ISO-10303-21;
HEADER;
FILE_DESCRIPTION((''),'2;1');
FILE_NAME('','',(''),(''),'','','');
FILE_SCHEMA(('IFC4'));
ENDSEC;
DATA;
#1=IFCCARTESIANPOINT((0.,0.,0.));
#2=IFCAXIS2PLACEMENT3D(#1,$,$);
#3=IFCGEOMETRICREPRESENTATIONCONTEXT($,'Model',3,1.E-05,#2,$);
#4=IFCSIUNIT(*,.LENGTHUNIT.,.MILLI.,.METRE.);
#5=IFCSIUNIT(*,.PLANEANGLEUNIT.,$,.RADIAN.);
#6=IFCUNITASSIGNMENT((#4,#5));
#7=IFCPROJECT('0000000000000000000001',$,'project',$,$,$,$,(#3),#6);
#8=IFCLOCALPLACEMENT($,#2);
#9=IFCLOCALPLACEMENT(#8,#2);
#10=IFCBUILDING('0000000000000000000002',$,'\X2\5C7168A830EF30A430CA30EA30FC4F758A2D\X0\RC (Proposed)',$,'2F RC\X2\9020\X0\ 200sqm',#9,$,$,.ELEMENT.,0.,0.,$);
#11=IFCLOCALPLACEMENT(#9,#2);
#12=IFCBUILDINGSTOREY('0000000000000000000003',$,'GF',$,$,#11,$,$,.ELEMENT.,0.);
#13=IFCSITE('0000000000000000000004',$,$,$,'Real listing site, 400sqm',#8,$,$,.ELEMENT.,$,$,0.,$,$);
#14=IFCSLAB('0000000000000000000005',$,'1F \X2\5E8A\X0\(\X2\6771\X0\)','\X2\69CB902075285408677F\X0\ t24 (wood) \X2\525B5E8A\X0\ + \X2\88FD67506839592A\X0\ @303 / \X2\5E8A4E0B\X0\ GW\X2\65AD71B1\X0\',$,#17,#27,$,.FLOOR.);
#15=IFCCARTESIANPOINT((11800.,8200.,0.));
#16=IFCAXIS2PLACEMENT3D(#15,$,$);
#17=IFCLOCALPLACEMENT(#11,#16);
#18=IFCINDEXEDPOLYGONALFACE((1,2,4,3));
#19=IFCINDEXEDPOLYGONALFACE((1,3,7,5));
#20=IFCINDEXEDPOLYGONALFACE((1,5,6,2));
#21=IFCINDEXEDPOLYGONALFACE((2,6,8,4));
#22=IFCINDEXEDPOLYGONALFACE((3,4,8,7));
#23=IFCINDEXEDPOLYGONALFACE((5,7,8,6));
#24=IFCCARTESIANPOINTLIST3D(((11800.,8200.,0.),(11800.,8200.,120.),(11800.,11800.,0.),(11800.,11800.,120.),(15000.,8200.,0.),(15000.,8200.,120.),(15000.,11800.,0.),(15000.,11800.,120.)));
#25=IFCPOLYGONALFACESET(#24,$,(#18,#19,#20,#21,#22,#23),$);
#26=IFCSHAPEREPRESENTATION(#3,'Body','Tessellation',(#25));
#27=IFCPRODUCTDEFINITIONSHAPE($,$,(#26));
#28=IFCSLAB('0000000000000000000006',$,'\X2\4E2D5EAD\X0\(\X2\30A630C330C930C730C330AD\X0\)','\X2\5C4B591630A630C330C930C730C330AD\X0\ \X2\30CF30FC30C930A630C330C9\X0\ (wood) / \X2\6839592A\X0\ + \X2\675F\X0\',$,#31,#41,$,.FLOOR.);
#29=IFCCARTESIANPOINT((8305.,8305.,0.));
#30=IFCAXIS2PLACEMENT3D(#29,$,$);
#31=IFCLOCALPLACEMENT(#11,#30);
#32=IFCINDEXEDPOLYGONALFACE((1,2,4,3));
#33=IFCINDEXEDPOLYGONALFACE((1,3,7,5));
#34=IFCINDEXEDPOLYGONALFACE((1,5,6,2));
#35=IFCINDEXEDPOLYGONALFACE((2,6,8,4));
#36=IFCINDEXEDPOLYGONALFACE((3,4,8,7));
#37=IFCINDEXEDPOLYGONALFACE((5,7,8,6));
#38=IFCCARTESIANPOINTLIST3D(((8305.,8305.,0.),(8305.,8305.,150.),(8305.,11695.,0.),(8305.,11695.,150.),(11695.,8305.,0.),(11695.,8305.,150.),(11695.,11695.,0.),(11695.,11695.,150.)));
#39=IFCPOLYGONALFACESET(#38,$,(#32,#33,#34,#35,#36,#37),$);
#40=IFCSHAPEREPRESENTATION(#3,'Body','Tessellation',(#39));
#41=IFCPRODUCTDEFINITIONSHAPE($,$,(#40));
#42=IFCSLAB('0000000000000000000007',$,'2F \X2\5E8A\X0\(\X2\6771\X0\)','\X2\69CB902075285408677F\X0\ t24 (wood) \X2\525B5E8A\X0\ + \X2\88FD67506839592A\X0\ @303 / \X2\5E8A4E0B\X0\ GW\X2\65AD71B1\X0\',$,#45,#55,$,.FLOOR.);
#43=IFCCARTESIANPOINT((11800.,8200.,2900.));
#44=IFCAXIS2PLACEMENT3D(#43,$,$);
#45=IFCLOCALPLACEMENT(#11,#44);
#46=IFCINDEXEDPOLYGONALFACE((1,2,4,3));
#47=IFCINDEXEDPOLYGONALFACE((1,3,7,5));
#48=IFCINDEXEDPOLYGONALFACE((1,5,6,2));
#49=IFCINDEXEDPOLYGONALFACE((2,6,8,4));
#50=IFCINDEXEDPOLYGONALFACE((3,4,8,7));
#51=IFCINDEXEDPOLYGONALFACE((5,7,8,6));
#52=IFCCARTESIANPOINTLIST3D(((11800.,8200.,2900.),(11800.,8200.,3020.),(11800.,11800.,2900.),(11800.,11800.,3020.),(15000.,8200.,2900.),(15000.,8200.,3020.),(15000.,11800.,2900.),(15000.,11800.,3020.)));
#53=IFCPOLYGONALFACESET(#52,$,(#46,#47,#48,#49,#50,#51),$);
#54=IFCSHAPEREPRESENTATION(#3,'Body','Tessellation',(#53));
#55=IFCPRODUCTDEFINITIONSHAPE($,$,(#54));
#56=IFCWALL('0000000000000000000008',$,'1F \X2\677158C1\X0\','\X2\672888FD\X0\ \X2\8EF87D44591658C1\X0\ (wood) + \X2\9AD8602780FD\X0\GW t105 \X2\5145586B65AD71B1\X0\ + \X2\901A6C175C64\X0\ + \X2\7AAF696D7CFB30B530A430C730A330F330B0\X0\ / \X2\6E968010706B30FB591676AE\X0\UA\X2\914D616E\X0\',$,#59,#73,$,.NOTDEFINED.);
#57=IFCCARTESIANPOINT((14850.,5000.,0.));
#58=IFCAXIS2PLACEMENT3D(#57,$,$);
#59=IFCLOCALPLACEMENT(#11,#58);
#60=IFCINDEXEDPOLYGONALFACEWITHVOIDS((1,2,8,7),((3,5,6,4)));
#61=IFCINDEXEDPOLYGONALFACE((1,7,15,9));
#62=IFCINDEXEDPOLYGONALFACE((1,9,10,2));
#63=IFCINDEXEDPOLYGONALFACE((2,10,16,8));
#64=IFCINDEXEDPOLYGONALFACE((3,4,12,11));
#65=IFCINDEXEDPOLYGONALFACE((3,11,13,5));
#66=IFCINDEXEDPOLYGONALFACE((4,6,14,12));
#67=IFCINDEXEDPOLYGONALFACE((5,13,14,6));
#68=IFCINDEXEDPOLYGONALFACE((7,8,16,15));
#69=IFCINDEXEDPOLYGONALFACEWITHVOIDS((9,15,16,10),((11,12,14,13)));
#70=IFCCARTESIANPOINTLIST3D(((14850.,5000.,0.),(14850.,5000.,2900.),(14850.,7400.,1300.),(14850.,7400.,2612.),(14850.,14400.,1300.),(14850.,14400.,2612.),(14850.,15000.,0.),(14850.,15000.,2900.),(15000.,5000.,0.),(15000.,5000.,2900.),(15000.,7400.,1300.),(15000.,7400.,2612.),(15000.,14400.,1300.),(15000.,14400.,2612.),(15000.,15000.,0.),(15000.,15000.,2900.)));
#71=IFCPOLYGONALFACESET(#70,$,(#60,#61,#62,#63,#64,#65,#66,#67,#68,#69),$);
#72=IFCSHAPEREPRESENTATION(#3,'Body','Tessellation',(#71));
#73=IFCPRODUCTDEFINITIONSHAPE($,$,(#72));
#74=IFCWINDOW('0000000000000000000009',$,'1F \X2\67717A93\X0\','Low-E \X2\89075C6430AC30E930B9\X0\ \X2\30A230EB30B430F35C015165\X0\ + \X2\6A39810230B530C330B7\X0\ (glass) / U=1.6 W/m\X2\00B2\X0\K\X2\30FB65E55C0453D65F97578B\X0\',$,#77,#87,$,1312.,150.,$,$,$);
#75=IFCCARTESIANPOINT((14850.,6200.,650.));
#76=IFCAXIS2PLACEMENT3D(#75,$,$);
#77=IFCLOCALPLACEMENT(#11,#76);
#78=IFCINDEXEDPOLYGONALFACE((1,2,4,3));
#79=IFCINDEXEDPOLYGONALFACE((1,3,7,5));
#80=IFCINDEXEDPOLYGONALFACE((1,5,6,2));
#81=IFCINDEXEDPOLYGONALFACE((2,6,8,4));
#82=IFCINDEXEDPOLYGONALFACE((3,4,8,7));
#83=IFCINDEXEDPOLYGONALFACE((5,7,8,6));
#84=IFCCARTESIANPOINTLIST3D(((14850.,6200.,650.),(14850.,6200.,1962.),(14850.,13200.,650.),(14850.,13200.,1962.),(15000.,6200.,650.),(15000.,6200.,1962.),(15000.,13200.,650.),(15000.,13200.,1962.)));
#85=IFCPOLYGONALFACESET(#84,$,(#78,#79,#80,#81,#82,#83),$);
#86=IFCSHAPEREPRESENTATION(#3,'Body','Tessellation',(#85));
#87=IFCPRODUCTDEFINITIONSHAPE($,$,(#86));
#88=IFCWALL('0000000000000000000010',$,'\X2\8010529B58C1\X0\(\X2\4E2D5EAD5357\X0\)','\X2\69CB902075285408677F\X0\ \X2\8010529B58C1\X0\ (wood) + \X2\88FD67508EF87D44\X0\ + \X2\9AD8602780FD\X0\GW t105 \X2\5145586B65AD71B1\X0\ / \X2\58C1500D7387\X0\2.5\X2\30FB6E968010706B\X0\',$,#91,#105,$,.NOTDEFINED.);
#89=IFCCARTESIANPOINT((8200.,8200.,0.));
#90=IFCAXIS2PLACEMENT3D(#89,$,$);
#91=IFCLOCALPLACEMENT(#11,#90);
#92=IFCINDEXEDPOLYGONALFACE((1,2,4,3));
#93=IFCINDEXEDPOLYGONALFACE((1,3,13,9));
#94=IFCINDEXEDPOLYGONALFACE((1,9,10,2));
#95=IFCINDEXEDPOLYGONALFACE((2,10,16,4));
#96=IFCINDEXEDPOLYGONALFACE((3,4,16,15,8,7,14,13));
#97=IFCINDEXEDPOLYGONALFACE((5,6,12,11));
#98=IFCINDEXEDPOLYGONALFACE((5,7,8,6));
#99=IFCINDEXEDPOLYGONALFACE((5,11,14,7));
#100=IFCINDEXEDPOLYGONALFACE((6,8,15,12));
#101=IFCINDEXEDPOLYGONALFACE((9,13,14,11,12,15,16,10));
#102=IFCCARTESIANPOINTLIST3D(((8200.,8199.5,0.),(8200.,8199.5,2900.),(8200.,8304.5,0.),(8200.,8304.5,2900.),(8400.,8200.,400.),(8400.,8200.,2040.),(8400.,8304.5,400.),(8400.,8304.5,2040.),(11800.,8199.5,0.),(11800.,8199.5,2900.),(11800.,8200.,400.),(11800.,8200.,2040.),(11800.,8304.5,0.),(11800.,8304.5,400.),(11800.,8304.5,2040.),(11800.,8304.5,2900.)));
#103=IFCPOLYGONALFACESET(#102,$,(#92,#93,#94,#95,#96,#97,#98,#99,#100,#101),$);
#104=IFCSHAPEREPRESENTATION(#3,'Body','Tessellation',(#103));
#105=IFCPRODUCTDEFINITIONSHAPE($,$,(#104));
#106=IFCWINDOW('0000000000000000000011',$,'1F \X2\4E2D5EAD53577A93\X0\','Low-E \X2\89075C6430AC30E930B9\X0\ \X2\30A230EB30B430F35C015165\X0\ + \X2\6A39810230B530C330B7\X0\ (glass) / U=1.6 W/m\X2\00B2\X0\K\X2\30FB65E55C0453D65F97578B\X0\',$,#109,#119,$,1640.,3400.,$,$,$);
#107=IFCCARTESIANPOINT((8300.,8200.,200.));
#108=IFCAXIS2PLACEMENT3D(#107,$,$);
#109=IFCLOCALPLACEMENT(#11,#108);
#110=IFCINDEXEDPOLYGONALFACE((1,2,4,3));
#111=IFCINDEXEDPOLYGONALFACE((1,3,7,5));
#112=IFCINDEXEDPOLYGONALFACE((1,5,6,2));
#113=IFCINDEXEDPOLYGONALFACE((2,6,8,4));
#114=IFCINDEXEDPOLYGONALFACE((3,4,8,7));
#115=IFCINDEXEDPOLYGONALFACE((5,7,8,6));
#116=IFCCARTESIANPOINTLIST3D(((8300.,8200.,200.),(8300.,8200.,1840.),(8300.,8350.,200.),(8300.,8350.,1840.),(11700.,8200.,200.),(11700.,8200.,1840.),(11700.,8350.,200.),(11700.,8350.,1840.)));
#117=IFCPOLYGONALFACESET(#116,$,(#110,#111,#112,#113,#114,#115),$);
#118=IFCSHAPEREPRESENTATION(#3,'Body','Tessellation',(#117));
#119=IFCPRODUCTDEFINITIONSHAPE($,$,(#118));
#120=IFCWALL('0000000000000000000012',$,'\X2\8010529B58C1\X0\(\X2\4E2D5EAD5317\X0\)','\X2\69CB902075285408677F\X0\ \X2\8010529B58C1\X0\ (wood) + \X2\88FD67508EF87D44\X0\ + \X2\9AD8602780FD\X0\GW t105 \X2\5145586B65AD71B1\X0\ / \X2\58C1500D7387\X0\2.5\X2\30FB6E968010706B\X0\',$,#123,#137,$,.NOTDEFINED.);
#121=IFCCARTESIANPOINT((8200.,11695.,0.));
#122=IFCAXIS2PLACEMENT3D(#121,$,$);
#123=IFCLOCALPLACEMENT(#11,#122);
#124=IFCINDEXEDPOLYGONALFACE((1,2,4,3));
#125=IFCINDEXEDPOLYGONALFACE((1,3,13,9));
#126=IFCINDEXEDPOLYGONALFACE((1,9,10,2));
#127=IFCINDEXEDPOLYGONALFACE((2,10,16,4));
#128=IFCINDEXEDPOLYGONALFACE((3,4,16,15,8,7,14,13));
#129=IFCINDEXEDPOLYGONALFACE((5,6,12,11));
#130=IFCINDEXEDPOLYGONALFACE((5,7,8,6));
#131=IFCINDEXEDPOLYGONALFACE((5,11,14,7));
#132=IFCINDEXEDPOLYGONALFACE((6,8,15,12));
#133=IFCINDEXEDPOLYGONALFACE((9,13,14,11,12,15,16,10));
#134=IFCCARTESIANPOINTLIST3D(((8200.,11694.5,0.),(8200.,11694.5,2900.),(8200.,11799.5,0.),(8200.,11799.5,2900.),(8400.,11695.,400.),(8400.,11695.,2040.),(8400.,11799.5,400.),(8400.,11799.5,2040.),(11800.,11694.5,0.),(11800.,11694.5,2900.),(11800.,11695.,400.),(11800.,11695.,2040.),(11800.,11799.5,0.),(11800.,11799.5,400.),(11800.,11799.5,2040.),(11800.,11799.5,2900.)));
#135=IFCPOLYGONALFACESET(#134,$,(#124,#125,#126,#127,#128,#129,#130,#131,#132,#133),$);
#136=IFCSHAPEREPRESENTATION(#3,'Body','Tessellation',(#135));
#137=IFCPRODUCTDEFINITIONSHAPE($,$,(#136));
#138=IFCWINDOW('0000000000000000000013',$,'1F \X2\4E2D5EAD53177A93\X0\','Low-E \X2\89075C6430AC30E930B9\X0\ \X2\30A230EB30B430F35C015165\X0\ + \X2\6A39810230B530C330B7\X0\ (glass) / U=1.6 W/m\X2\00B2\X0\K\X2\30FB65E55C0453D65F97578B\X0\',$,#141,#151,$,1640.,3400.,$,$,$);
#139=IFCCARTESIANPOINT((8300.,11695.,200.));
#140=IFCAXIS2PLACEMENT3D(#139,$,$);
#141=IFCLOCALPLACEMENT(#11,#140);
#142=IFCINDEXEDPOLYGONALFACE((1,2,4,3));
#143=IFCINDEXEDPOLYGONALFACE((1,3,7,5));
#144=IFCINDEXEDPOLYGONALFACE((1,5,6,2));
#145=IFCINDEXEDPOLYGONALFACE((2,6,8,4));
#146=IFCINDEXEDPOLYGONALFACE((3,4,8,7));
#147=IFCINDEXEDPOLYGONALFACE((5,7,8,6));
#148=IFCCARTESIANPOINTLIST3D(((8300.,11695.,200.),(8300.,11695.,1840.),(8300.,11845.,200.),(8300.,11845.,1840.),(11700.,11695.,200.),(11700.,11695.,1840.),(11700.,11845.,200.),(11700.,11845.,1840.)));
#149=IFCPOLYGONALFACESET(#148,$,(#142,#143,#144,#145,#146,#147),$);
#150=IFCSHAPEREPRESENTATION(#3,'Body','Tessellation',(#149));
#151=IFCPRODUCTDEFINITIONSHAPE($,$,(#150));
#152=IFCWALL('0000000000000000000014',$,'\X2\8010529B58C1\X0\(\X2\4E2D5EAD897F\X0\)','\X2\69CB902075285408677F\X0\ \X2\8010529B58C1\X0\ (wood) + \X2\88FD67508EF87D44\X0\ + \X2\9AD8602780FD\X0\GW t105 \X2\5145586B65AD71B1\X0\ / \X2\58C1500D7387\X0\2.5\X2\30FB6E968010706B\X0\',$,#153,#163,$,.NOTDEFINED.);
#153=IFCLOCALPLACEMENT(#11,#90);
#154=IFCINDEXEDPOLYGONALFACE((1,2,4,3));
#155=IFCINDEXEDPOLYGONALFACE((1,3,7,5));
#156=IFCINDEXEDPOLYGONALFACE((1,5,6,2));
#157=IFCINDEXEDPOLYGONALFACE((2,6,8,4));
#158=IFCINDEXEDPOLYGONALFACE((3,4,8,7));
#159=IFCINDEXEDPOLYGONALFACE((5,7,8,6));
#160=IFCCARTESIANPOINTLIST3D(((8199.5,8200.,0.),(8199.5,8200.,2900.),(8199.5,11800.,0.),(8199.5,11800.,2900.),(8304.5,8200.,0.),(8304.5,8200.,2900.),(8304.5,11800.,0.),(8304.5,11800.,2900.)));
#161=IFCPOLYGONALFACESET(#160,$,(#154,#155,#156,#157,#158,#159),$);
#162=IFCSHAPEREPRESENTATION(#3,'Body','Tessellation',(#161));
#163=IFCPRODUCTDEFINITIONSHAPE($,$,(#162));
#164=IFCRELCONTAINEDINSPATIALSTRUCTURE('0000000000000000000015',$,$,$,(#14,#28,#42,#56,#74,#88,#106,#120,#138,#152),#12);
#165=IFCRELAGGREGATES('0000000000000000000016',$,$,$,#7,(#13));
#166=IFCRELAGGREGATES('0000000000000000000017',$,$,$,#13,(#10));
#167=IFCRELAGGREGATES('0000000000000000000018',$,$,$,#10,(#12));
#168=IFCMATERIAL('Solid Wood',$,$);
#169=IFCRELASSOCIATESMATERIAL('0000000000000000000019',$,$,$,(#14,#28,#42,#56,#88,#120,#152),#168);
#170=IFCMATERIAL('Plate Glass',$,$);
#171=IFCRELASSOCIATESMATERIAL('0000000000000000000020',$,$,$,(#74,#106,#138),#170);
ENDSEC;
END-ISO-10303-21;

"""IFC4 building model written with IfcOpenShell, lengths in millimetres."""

from ifc_helpers import new_model, si_unit, frame, frame_2d, origin, place, context, project, spatial, rectangle, extrude, material, element, fill, save


model = new_model("IFC4")

# Units and contexts
model_context = context("Model", 3, precision=1e-05, world=origin())
ifc_project = project(units=[si_unit("LENGTHUNIT", "METRE", prefix="MILLI"), si_unit("PLANEANGLEUNIT", "RADIAN")], contexts=[model_context])

# Site, building, storey
site_placement = place(None, origin())
site = spatial("IfcSite", under=ifc_project, at=site_placement, ObjectType="Real listing site, 400sqm", CompositionType="ELEMENT", RefElevation=0.0)
building_placement = place(site_placement, origin())
building = spatial("IfcBuilding", under=site, at=building_placement, Name="山梨ワイナリー併設RC (Proposed)", ObjectType="2F RC造 200sqm", CompositionType="ELEMENT", ElevationOfRefHeight=0.0, ElevationOfTerrain=0.0)
storey_placement = place(building_placement, origin())
storey = spatial("IfcBuildingStorey", under=building, at=storey_placement, Name="GF", CompositionType="ELEMENT", Elevation=0.0)

# Slabs
ifc_material_1 = material(Name="Solid Wood")
slab_1_placement = place(storey_placement, frame((11800.0, 8200.0, 0.0)))
element("IfcSlab", 1, at=slab_1_placement, inside=storey, material=ifc_material_1, Name="1F 床(東)", Description="構造用合板 t24 (wood) 剛床 + 製材根太 @303 / 床下 GW断熱", PredefinedType="FLOOR", context=model_context, shape_type="SweptSolid", body=[
    extrude(rectangle(XDim=3200.0, YDim=3600.0, at=frame_2d((1600.0, 1800.0))), frame((11800.0, 8200.0, 0.0)), (0.0, 0.0, 1.0), 120.0),
])
slab_2_placement = place(storey_placement, frame((8305.0, 8305.0, 0.0)))
element("IfcSlab", 2, at=slab_2_placement, inside=storey, material=ifc_material_1, Name="中庭(ウッドデッキ)", Description="屋外ウッドデッキ ハードウッド (wood) / 根太 + 束", PredefinedType="FLOOR", context=model_context, shape_type="SweptSolid", body=[
    extrude(rectangle(XDim=3390.0, YDim=3390.0, at=frame_2d((1695.0, 1695.0))), frame((8305.0, 8305.0, 0.0)), (0.0, 0.0, 1.0), 150.0),
])
slab_3_placement = place(storey_placement, frame((11800.0, 8200.0, 2900.0)))
element("IfcSlab", 3, at=slab_3_placement, inside=storey, material=ifc_material_1, Name="2F 床(東)", Description="構造用合板 t24 (wood) 剛床 + 製材根太 @303 / 床下 GW断熱", PredefinedType="FLOOR", context=model_context, shape_type="SweptSolid", body=[
    extrude(rectangle(XDim=3200.0, YDim=3600.0, at=frame_2d((1600.0, 1800.0))), frame((11800.0, 8200.0, 2900.0)), (0.0, 0.0, 1.0), 120.0),
])

# Walls, openings, windows
wall_1_placement = place(storey_placement, frame((14850.0, 5000.0, 0.0)))
wall_1 = element("IfcWall", 4, at=wall_1_placement, inside=storey, material=ifc_material_1, Name="1F 東壁", Description="木製 軸組外壁 (wood) + 高性能GW t105 充填断熱 + 通気層 + 窯業系サイディング / 準耐火・外皮UA配慮", PredefinedType="NOTDEFINED", context=model_context, shape_type="SweptSolid", body=[
    extrude(rectangle(XDim=150.0, YDim=10000.0, at=frame_2d((75.0, 5000.0))), frame((14850.0, 5000.0, 0.0)), (0.0, 0.0, 1.0), 2900.0),
])
opening_1_placement = place(storey_placement, frame((14850.0, 6200.0, 650.0)))
opening_1 = element("IfcOpeningElement", 5, at=opening_1_placement, cuts=wall_1, PredefinedType="NOTDEFINED", context=model_context, shape_type="SweptSolid", body=[
    extrude(rectangle(XDim=150.0, YDim=7000.0, at=frame_2d((75.0, 3500.0))), frame((14850.0, 6200.0, 650.0)), (0.0, 0.0, 1.0), 1312.0),
])
ifc_material_2 = material(Name="Plate Glass")
window_1_placement = place(storey_placement, frame((14850.0, 6200.0, 650.0)))
window_1 = element("IfcWindow", 6, at=window_1_placement, inside=storey, material=ifc_material_2, Name="1F 東窓", Description="Low-E 複層ガラス アルゴン封入 + 樹脂サッシ (glass) / U=1.6 W/m²K・日射取得型", OverallHeight=1312.0, OverallWidth=150.0, context=model_context, shape_type="SweptSolid", body=[
    extrude(rectangle(XDim=150.0, YDim=7000.0, at=frame_2d((75.0, 3500.0))), frame((14850.0, 6200.0, 650.0)), (0.0, 0.0, 1.0), 1312.0),
])
fill(opening_1, window_1)
wall_2_placement = place(storey_placement, frame((8200.0, 8200.0, 0.0)))
wall_2 = element("IfcWall", 7, at=wall_2_placement, inside=storey, material=ifc_material_1, Name="耐力壁(中庭南)", Description="構造用合板 耐力壁 (wood) + 製材軸組 + 高性能GW t105 充填断熱 / 壁倍率2.5・準耐火", PredefinedType="NOTDEFINED", context=model_context, shape_type="SweptSolid", body=[
    extrude(rectangle(XDim=3600.0, YDim=105.0, at=frame_2d((1800.0, 52.0))), frame((8200.0, 8200.0, 0.0)), (0.0, 0.0, 1.0), 2900.0),
])
opening_2_placement = place(storey_placement, frame((8300.0, 8200.0, 200.0)))
opening_2 = element("IfcOpeningElement", 8, at=opening_2_placement, cuts=wall_2, PredefinedType="NOTDEFINED", context=model_context, shape_type="SweptSolid", body=[
    extrude(rectangle(XDim=3400.0, YDim=150.0, at=frame_2d((1700.0, 75.0))), frame((8300.0, 8200.0, 200.0)), (0.0, 0.0, 1.0), 1640.0),
])
window_2_placement = place(storey_placement, frame((8300.0, 8200.0, 200.0)))
window_2 = element("IfcWindow", 9, at=window_2_placement, inside=storey, material=ifc_material_2, Name="1F 中庭南窓", Description="Low-E 複層ガラス アルゴン封入 + 樹脂サッシ (glass) / U=1.6 W/m²K・日射取得型", OverallHeight=1640.0, OverallWidth=3400.0, context=model_context, shape_type="SweptSolid", body=[
    extrude(rectangle(XDim=3400.0, YDim=150.0, at=frame_2d((1700.0, 75.0))), frame((8300.0, 8200.0, 200.0)), (0.0, 0.0, 1.0), 1640.0),
])
fill(opening_2, window_2)
wall_3_placement = place(storey_placement, frame((8200.0, 11695.0, 0.0)))
wall_3 = element("IfcWall", 10, at=wall_3_placement, inside=storey, material=ifc_material_1, Name="耐力壁(中庭北)", Description="構造用合板 耐力壁 (wood) + 製材軸組 + 高性能GW t105 充填断熱 / 壁倍率2.5・準耐火", PredefinedType="NOTDEFINED", context=model_context, shape_type="SweptSolid", body=[
    extrude(rectangle(XDim=3600.0, YDim=105.0, at=frame_2d((1800.0, 52.0))), frame((8200.0, 11695.0, 0.0)), (0.0, 0.0, 1.0), 2900.0),
])
opening_3_placement = place(storey_placement, frame((8300.0, 11695.0, 200.0)))
opening_3 = element("IfcOpeningElement", 11, at=opening_3_placement, cuts=wall_3, PredefinedType="NOTDEFINED", context=model_context, shape_type="SweptSolid", body=[
    extrude(rectangle(XDim=3400.0, YDim=150.0, at=frame_2d((1700.0, 75.0))), frame((8300.0, 11695.0, 200.0)), (0.0, 0.0, 1.0), 1640.0),
])
window_3_placement = place(storey_placement, frame((8300.0, 11695.0, 200.0)))
window_3 = element("IfcWindow", 12, at=window_3_placement, inside=storey, material=ifc_material_2, Name="1F 中庭北窓", Description="Low-E 複層ガラス アルゴン封入 + 樹脂サッシ (glass) / U=1.6 W/m²K・日射取得型", OverallHeight=1640.0, OverallWidth=3400.0, context=model_context, shape_type="SweptSolid", body=[
    extrude(rectangle(XDim=3400.0, YDim=150.0, at=frame_2d((1700.0, 75.0))), frame((8300.0, 11695.0, 200.0)), (0.0, 0.0, 1.0), 1640.0),
])
fill(opening_3, window_3)

# Wall
wall_4_placement = place(storey_placement, frame((8200.0, 8200.0, 0.0)))
element("IfcWall", 13, at=wall_4_placement, inside=storey, material=ifc_material_1, Name="耐力壁(中庭西)", Description="構造用合板 耐力壁 (wood) + 製材軸組 + 高性能GW t105 充填断熱 / 壁倍率2.5・準耐火", PredefinedType="NOTDEFINED", context=model_context, shape_type="SweptSolid", body=[
    extrude(rectangle(XDim=105.0, YDim=3600.0, at=frame_2d((52.0, 1800.0))), frame((8200.0, 8200.0, 0.0)), (0.0, 0.0, 1.0), 2900.0),
])

save(model, "model.ifc")
